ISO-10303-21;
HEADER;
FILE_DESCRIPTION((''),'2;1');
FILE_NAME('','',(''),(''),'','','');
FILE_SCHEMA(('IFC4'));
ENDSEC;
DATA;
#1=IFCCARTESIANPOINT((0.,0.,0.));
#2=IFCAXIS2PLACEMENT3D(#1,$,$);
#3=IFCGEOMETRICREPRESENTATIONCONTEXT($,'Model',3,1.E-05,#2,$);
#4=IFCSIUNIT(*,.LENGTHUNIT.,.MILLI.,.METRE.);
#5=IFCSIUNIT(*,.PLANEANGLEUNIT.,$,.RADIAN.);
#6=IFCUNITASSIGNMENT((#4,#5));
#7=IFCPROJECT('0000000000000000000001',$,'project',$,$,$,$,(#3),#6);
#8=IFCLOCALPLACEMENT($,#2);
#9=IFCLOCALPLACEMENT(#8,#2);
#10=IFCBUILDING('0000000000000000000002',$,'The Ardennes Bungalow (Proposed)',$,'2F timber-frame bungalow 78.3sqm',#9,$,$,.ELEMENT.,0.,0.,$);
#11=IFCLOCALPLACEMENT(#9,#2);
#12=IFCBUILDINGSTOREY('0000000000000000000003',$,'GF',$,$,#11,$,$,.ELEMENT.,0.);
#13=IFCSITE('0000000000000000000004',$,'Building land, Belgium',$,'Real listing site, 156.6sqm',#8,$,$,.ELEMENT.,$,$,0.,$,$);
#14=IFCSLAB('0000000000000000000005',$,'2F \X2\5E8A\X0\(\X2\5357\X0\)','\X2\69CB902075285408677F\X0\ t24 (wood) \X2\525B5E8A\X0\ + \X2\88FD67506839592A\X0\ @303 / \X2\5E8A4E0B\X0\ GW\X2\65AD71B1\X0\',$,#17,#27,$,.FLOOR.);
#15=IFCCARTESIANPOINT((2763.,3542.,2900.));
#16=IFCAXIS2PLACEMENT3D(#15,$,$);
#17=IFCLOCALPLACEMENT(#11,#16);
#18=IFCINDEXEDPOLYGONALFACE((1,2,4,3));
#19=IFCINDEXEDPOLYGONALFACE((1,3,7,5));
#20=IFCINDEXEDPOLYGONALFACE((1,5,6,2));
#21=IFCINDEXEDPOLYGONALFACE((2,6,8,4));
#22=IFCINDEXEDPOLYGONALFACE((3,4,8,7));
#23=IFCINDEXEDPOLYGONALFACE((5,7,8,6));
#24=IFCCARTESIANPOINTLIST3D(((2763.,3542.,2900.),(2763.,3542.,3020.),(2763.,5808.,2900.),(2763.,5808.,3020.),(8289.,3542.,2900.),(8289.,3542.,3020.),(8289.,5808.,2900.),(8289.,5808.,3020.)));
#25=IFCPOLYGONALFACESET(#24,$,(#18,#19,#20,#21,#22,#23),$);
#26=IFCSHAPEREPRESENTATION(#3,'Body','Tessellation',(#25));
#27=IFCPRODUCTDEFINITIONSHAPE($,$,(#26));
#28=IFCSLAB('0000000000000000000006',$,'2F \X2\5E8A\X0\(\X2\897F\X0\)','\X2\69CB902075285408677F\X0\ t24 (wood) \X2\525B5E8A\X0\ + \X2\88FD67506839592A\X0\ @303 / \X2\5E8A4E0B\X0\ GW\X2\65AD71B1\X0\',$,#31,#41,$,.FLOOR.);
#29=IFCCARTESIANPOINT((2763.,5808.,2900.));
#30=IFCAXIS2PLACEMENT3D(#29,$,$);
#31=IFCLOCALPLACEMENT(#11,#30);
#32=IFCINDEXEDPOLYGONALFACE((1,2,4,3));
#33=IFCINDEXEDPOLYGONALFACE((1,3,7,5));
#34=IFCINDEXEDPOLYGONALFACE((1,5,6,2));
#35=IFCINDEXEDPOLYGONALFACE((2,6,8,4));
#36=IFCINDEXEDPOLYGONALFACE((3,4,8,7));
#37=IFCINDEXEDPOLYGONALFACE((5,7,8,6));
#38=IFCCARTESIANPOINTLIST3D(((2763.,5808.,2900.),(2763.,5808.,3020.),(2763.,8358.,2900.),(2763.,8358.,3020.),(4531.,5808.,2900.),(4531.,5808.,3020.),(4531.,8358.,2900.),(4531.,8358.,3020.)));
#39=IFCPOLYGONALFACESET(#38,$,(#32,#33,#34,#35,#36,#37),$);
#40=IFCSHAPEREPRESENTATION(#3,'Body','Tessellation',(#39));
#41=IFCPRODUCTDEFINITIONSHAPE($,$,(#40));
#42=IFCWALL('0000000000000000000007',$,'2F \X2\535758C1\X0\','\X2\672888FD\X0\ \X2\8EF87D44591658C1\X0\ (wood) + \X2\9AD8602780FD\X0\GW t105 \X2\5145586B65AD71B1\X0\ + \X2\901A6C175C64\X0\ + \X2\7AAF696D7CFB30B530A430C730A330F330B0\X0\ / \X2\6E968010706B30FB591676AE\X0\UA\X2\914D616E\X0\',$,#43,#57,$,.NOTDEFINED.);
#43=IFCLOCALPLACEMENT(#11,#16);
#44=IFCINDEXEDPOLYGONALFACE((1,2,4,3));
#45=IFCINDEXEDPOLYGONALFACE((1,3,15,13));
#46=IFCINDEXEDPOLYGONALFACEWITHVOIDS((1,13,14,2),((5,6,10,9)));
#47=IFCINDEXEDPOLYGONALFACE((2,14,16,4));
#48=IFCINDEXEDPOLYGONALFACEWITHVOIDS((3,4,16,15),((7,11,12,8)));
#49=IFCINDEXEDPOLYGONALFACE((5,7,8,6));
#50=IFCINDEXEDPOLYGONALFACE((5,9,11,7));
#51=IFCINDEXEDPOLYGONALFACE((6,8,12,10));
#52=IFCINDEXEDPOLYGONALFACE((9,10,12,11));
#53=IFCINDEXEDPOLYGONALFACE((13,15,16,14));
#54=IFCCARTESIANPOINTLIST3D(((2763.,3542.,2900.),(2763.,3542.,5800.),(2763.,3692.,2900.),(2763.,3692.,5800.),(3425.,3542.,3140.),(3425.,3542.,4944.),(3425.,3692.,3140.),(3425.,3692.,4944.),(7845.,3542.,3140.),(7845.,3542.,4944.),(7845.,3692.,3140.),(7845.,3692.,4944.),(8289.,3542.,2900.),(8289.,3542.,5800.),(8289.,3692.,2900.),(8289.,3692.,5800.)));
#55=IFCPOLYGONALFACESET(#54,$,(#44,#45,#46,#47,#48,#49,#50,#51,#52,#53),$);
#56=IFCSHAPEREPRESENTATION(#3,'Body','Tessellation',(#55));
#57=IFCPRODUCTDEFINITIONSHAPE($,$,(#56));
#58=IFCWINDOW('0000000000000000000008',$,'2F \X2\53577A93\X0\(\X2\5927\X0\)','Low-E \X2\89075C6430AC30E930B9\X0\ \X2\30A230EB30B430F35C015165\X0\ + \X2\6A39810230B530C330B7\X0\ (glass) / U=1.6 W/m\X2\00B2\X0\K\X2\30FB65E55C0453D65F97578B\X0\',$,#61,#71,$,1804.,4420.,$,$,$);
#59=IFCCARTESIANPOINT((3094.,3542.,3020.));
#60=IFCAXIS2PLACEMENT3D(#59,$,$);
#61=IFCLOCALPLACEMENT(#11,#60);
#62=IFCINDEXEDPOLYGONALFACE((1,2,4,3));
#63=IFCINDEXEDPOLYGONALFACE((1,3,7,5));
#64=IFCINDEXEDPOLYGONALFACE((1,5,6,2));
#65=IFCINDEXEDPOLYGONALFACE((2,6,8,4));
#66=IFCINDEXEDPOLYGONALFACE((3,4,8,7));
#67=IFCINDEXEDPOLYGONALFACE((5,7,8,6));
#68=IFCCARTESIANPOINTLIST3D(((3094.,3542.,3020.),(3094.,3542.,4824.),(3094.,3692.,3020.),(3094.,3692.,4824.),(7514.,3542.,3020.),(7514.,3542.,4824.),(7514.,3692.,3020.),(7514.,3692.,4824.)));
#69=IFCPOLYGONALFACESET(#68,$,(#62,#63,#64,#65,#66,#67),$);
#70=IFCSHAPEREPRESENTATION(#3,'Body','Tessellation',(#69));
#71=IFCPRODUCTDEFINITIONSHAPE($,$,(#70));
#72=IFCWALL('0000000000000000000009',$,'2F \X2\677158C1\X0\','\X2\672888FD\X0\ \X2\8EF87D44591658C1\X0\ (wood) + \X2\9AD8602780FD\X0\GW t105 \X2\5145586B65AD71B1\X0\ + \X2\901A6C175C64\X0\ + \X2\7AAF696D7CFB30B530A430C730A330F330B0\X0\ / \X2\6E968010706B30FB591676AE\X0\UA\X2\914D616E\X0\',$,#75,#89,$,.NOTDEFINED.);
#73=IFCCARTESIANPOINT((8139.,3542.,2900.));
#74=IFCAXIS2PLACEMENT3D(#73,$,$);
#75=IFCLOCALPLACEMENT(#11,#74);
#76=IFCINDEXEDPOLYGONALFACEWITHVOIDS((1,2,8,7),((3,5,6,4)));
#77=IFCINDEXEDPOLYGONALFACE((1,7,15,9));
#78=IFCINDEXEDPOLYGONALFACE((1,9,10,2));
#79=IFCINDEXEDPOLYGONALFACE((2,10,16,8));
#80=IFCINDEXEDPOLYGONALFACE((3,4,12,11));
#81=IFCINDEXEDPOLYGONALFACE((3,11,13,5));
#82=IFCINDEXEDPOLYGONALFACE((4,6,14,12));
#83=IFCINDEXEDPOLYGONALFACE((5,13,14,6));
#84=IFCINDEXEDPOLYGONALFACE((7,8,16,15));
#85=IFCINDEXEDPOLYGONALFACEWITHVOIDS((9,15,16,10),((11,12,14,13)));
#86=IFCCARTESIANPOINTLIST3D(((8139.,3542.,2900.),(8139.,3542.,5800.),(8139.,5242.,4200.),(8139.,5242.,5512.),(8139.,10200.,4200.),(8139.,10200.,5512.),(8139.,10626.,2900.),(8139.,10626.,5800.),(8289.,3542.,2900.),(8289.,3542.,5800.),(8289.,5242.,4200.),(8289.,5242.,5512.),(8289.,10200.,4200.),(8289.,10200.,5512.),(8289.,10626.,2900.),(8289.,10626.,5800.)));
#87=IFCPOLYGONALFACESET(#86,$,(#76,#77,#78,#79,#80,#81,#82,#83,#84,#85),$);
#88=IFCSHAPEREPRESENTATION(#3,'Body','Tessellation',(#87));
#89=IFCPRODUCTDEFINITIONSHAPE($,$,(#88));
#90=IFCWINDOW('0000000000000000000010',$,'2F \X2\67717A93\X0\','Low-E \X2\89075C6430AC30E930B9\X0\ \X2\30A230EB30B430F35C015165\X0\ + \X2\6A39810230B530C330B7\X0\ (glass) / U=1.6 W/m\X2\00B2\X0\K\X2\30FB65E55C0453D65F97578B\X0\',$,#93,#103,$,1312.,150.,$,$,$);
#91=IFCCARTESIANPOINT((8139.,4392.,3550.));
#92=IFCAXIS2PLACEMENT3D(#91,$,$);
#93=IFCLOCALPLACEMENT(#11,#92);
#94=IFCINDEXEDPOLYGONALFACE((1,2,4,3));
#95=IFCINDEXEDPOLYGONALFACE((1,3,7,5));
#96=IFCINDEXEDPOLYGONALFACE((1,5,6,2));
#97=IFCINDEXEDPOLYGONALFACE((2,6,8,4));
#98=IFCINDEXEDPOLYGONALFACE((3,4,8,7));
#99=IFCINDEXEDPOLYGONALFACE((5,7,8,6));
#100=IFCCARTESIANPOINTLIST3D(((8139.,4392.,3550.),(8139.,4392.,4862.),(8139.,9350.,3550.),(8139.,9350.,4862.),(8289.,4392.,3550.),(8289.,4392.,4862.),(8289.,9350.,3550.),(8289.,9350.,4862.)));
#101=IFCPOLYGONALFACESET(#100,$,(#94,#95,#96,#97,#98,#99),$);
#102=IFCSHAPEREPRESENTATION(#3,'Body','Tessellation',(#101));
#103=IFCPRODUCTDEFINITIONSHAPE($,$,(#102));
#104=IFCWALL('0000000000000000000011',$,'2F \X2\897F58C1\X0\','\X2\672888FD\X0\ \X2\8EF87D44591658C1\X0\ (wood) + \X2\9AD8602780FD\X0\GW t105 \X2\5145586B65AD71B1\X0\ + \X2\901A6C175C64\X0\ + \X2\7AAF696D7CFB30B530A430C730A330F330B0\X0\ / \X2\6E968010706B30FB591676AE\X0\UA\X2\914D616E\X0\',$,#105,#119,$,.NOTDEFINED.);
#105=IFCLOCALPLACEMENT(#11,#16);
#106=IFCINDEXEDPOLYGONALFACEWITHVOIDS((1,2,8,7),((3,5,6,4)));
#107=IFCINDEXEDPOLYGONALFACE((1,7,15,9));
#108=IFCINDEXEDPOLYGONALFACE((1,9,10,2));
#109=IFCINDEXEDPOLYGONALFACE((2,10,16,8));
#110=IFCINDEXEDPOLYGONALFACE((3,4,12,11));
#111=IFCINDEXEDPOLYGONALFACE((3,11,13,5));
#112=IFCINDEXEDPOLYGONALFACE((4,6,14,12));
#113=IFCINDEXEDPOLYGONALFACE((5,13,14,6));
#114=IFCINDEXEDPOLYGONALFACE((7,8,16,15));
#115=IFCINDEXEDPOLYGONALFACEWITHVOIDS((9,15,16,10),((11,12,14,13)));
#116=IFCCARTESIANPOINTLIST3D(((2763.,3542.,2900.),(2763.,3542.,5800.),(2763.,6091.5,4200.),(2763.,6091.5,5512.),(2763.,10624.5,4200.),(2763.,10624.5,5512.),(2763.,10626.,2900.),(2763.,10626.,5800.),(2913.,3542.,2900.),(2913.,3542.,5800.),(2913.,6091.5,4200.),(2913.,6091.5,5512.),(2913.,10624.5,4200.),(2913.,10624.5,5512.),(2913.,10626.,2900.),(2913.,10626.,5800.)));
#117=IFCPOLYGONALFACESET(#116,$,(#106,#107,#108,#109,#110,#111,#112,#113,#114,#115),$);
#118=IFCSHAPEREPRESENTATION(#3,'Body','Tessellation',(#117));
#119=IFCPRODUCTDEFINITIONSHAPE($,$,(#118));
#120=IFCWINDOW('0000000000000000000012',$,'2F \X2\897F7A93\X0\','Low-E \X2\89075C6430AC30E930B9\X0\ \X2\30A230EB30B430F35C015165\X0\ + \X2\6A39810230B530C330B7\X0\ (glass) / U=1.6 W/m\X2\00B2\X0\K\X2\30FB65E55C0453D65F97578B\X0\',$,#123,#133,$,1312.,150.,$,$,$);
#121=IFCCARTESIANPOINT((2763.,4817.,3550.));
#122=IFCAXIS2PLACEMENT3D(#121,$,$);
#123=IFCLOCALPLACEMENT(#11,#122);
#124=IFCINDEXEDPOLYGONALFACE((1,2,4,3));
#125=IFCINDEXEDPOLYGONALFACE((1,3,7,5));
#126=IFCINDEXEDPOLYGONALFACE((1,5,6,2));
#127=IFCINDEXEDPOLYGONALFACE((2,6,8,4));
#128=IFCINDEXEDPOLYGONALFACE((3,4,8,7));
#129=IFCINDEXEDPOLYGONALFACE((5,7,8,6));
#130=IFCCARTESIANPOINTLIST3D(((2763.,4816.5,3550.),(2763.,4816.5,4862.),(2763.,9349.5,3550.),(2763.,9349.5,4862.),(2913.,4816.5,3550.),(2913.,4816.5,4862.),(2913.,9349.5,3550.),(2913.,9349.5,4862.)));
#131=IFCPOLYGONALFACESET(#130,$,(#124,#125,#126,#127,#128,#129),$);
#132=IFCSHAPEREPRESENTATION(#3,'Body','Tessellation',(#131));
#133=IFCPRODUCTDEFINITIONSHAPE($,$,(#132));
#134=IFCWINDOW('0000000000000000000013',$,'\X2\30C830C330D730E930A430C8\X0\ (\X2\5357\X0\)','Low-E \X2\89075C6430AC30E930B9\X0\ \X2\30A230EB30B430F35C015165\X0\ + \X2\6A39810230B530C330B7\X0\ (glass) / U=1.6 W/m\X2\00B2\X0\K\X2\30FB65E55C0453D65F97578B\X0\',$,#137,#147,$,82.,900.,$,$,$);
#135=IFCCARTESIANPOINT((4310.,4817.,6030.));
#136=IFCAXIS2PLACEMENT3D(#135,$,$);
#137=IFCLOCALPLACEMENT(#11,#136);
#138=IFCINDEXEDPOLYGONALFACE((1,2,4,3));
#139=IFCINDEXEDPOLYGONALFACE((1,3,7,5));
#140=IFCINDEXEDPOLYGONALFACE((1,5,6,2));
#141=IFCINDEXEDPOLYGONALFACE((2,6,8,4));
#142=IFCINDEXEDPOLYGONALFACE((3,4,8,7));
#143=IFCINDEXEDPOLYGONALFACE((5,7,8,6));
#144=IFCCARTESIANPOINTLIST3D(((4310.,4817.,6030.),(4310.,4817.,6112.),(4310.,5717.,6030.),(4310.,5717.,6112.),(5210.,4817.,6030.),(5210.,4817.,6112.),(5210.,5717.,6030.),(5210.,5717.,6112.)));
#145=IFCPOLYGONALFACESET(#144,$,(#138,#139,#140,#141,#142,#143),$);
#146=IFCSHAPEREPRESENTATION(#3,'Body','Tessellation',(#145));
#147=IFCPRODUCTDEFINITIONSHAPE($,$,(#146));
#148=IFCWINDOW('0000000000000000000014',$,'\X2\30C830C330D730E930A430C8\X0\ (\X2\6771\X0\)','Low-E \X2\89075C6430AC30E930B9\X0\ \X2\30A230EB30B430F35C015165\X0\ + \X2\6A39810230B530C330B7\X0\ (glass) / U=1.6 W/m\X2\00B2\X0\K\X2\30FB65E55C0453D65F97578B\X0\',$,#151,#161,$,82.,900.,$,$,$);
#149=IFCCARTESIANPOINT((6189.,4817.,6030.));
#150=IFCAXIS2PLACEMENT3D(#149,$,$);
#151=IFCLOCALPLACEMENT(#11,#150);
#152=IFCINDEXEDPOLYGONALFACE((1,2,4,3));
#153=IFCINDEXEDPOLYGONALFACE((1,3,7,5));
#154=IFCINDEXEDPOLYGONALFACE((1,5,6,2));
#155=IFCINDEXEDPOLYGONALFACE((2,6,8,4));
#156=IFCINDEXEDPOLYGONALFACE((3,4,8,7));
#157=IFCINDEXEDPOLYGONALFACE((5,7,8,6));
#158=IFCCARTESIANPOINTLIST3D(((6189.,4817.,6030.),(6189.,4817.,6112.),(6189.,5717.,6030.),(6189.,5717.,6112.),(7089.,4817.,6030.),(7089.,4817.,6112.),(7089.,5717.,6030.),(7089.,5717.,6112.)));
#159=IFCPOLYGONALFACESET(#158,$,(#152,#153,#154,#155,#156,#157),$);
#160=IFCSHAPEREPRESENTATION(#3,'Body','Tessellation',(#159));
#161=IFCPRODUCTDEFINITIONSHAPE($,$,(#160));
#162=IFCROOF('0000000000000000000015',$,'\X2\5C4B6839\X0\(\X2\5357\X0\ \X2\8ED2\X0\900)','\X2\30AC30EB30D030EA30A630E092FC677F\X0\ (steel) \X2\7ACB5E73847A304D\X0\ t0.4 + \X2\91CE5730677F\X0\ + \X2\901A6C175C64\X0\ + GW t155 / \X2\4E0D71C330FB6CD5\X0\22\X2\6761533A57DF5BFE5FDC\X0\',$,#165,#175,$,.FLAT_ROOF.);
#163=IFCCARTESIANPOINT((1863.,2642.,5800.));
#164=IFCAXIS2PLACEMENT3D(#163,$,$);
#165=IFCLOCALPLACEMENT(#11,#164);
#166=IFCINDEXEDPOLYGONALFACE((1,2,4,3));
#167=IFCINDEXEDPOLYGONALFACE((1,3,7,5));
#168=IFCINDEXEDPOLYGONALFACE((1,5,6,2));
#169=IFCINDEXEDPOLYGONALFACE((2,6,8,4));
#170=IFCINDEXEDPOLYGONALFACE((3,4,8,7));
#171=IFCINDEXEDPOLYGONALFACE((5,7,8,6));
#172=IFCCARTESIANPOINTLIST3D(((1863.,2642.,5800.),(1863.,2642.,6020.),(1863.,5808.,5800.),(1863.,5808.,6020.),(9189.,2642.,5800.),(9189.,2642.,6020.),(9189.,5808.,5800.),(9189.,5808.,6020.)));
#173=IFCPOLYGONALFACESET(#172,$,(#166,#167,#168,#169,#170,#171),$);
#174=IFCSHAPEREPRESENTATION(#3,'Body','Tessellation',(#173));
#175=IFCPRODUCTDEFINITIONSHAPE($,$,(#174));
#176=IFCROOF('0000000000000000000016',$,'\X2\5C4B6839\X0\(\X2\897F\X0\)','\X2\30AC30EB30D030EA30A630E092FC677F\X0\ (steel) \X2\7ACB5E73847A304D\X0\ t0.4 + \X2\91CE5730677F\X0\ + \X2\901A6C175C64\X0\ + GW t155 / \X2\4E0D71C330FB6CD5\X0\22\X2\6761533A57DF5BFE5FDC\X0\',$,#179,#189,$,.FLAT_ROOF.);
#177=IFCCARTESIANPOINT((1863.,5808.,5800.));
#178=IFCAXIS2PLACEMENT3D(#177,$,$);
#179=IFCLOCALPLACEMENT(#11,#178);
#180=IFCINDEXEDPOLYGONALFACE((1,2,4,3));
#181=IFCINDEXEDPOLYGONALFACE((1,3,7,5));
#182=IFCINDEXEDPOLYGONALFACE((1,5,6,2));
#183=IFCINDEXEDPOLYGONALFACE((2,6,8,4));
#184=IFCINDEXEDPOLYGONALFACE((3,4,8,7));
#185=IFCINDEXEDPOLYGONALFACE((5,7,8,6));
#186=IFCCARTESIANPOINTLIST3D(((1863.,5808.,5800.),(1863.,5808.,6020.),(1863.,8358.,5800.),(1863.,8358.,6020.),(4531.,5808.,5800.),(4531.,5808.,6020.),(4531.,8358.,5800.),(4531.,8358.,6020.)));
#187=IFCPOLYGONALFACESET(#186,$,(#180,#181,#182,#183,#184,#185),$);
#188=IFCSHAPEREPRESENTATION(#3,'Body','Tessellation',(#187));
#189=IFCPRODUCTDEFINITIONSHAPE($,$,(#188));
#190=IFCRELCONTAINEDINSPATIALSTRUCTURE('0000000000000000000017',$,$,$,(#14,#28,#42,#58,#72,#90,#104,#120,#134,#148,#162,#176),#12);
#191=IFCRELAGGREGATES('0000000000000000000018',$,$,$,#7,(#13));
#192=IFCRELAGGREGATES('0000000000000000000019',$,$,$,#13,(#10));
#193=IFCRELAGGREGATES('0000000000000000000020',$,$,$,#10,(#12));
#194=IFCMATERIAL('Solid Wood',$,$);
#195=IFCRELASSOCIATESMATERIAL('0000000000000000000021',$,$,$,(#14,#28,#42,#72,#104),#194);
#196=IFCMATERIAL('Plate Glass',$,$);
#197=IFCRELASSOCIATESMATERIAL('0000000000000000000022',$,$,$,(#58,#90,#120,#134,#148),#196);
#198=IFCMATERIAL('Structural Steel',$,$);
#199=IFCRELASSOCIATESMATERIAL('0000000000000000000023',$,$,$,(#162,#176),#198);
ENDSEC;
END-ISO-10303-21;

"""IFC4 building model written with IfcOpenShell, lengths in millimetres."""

from ifc_helpers import new_model, si_unit, frame, frame_2d, origin, place, context, project, spatial, rectangle, extrude, material, element, fill, save


model = new_model("IFC4")

# Units and contexts
model_context = context("Model", 3, precision=1e-05, world=origin())
ifc_project = project(units=[si_unit("LENGTHUNIT", "METRE", prefix="MILLI"), si_unit("PLANEANGLEUNIT", "RADIAN")], contexts=[model_context])

# Site, building, storey
site_placement = place(None, origin())
site = spatial("IfcSite", under=ifc_project, at=site_placement, Name="Building land, Belgium", ObjectType="Real listing site, 156.6sqm", CompositionType="ELEMENT", RefElevation=0.0)
building_placement = place(site_placement, origin())
building = spatial("IfcBuilding", under=site, at=building_placement, Name="The Ardennes Bungalow (Proposed)", ObjectType="2F timber-frame bungalow 78.3sqm", CompositionType="ELEMENT", ElevationOfRefHeight=0.0, ElevationOfTerrain=0.0)
storey_placement = place(building_placement, origin())
storey = spatial("IfcBuildingStorey", under=building, at=storey_placement, Name="GF", CompositionType="ELEMENT", Elevation=0.0)

# Slabs
ifc_material_1 = material(Name="Solid Wood")
slab_1_placement = place(storey_placement, frame((2763.0, 3542.0, 2900.0)))
element("IfcSlab", 1, at=slab_1_placement, inside=storey, material=ifc_material_1, Name="2F 床(南)", Description="構造用合板 t24 (wood) 剛床 + 製材根太 @303 / 床下 GW断熱", PredefinedType="FLOOR", context=model_context, shape_type="SweptSolid", body=[
    extrude(rectangle(XDim=5526.0, YDim=2266.0, at=frame_2d((2763.0, 1133.0))), frame((2763.0, 3542.0, 2900.0)), (0.0, 0.0, 1.0), 120.0),
])
slab_2_placement = place(storey_placement, frame((2763.0, 5808.0, 2900.0)))
element("IfcSlab", 2, at=slab_2_placement, inside=storey, material=ifc_material_1, Name="2F 床(西)", Description="構造用合板 t24 (wood) 剛床 + 製材根太 @303 / 床下 GW断熱", PredefinedType="FLOOR", context=model_context, shape_type="SweptSolid", body=[
    extrude(rectangle(XDim=1768.0, YDim=2550.0, at=frame_2d((884.0, 1275.0))), frame((2763.0, 5808.0, 2900.0)), (0.0, 0.0, 1.0), 120.0),
])

# Walls, openings, windows
wall_1_placement = place(storey_placement, frame((2763.0, 3542.0, 2900.0)))
wall_1 = element("IfcWall", 3, at=wall_1_placement, inside=storey, material=ifc_material_1, Name="2F 南壁", Description="木製 軸組外壁 (wood) + 高性能GW t105 充填断熱 + 通気層 + 窯業系サイディング / 準耐火・外皮UA配慮", PredefinedType="NOTDEFINED", context=model_context, shape_type="SweptSolid", body=[
    extrude(rectangle(XDim=5526.0, YDim=150.0, at=frame_2d((2763.0, 75.0))), frame((2763.0, 3542.0, 2900.0)), (0.0, 0.0, 1.0), 2900.0),
])
opening_1_placement = place(storey_placement, frame((3094.0, 3542.0, 3020.0)))
opening_1 = element("IfcOpeningElement", 4, at=opening_1_placement, cuts=wall_1, PredefinedType="NOTDEFINED", context=model_context, shape_type="SweptSolid", body=[
    extrude(rectangle(XDim=4420.0, YDim=150.0, at=frame_2d((2210.0, 75.0))), frame((3094.0, 3542.0, 3020.0)), (0.0, 0.0, 1.0), 1804.0),
])
ifc_material_2 = material(Name="Plate Glass")
window_1_placement = place(storey_placement, frame((3094.0, 3542.0, 3020.0)))
window_1 = element("IfcWindow", 5, at=window_1_placement, inside=storey, material=ifc_material_2, Name="2F 南窓(大)", Description="Low-E 複層ガラス アルゴン封入 + 樹脂サッシ (glass) / U=1.6 W/m²K・日射取得型", OverallHeight=1804.0, OverallWidth=4420.0, context=model_context, shape_type="SweptSolid", body=[
    extrude(rectangle(XDim=4420.0, YDim=150.0, at=frame_2d((2210.0, 75.0))), frame((3094.0, 3542.0, 3020.0)), (0.0, 0.0, 1.0), 1804.0),
])
fill(opening_1, window_1)
wall_2_placement = place(storey_placement, frame((8139.0, 3542.0, 2900.0)))
wall_2 = element("IfcWall", 6, at=wall_2_placement, inside=storey, material=ifc_material_1, Name="2F 東壁", Description="木製 軸組外壁 (wood) + 高性能GW t105 充填断熱 + 通気層 + 窯業系サイディング / 準耐火・外皮UA配慮", PredefinedType="NOTDEFINED", context=model_context, shape_type="SweptSolid", body=[
    extrude(rectangle(XDim=150.0, YDim=7084.0, at=frame_2d((75.0, 3542.0))), frame((8139.0, 3542.0, 2900.0)), (0.0, 0.0, 1.0), 2900.0),
])
opening_2_placement = place(storey_placement, frame((8139.0, 4392.0, 3550.0)))
opening_2 = element("IfcOpeningElement", 7, at=opening_2_placement, cuts=wall_2, PredefinedType="NOTDEFINED", context=model_context, shape_type="SweptSolid", body=[
    extrude(rectangle(XDim=150.0, YDim=4958.0, at=frame_2d((75.0, 2479.0))), frame((8139.0, 4392.0, 3550.0)), (0.0, 0.0, 1.0), 1312.0),
])
window_2_placement = place(storey_placement, frame((8139.0, 4392.0, 3550.0)))
window_2 = element("IfcWindow", 8, at=window_2_placement, inside=storey, material=ifc_material_2, Name="2F 東窓", Description="Low-E 複層ガラス アルゴン封入 + 樹脂サッシ (glass) / U=1.6 W/m²K・日射取得型", OverallHeight=1312.0, OverallWidth=150.0, context=model_context, shape_type="SweptSolid", body=[
    extrude(rectangle(XDim=150.0, YDim=4958.0, at=frame_2d((75.0, 2479.0))), frame((8139.0, 4392.0, 3550.0)), (0.0, 0.0, 1.0), 1312.0),
])
fill(opening_2, window_2)
wall_3_placement = place(storey_placement, frame((2763.0, 3542.0, 2900.0)))
wall_3 = element("IfcWall", 9, at=wall_3_placement, inside=storey, material=ifc_material_1, Name="2F 西壁", Description="木製 軸組外壁 (wood) + 高性能GW t105 充填断熱 + 通気層 + 窯業系サイディング / 準耐火・外皮UA配慮", PredefinedType="NOTDEFINED", context=model_context, shape_type="SweptSolid", body=[
    extrude(rectangle(XDim=150.0, YDim=7084.0, at=frame_2d((75.0, 3542.0))), frame((2763.0, 3542.0, 2900.0)), (0.0, 0.0, 1.0), 2900.0),
])
opening_3_placement = place(storey_placement, frame((2763.0, 4817.0, 3550.0)))
opening_3 = element("IfcOpeningElement", 10, at=opening_3_placement, cuts=wall_3, PredefinedType="NOTDEFINED", context=model_context, shape_type="SweptSolid", body=[
    extrude(rectangle(XDim=150.0, YDim=4533.0, at=frame_2d((75.0, 2266.0))), frame((2763.0, 4817.0, 3550.0)), (0.0, 0.0, 1.0), 1312.0),
])
window_3_placement = place(storey_placement, frame((2763.0, 4817.0, 3550.0)))
window_3 = element("IfcWindow", 11, at=window_3_placement, inside=storey, material=ifc_material_2, Name="2F 西窓", Description="Low-E 複層ガラス アルゴン封入 + 樹脂サッシ (glass) / U=1.6 W/m²K・日射取得型", OverallHeight=1312.0, OverallWidth=150.0, context=model_context, shape_type="SweptSolid", body=[
    extrude(rectangle(XDim=150.0, YDim=4533.0, at=frame_2d((75.0, 2266.0))), frame((2763.0, 4817.0, 3550.0)), (0.0, 0.0, 1.0), 1312.0),
])
fill(opening_3, window_3)

# Windows
window_4_placement = place(storey_placement, frame((4310.0, 4817.0, 6030.0)))
element("IfcWindow", 12, at=window_4_placement, inside=storey, material=ifc_material_2, Name="トップライト (南)", Description="Low-E 複層ガラス アルゴン封入 + 樹脂サッシ (glass) / U=1.6 W/m²K・日射取得型", OverallHeight=82.0, OverallWidth=900.0, context=model_context, shape_type="SweptSolid", body=[
    extrude(rectangle(XDim=900.0, YDim=900.0, at=frame_2d((450.0, 450.0))), frame((4310.0, 4817.0, 6030.0)), (0.0, 0.0, 1.0), 82.0),
])
window_5_placement = place(storey_placement, frame((6189.0, 4817.0, 6030.0)))
element("IfcWindow", 13, at=window_5_placement, inside=storey, material=ifc_material_2, Name="トップライト (東)", Description="Low-E 複層ガラス アルゴン封入 + 樹脂サッシ (glass) / U=1.6 W/m²K・日射取得型", OverallHeight=82.0, OverallWidth=900.0, context=model_context, shape_type="SweptSolid", body=[
    extrude(rectangle(XDim=900.0, YDim=900.0, at=frame_2d((450.0, 450.0))), frame((6189.0, 4817.0, 6030.0)), (0.0, 0.0, 1.0), 82.0),
])

# Roofs
ifc_material_3 = material(Name="Structural Steel")
roof_1_placement = place(storey_placement, frame((1863.0, 2642.0, 5800.0)))
element("IfcRoof", 14, at=roof_1_placement, inside=storey, material=ifc_material_3, Name="屋根(南 軒900)", Description="ガルバリウム鋼板 (steel) 立平葺き t0.4 + 野地板 + 通気層 + GW t155 / 不燃・法22条区域対応", PredefinedType="FLAT_ROOF", context=model_context, shape_type="SweptSolid", body=[
    extrude(rectangle(XDim=7326.0, YDim=3166.0, at=frame_2d((3663.0, 1583.0))), frame((1863.0, 2642.0, 5800.0)), (0.0, 0.0, 1.0), 220.0),
])
roof_2_placement = place(storey_placement, frame((1863.0, 5808.0, 5800.0)))
element("IfcRoof", 15, at=roof_2_placement, inside=storey, material=ifc_material_3, Name="屋根(西)", Description="ガルバリウム鋼板 (steel) 立平葺き t0.4 + 野地板 + 通気層 + GW t155 / 不燃・法22条区域対応", PredefinedType="FLAT_ROOF", context=model_context, shape_type="SweptSolid", body=[
    extrude(rectangle(XDim=2668.0, YDim=2550.0, at=frame_2d((1334.0, 1275.0))), frame((1863.0, 5808.0, 5800.0)), (0.0, 0.0, 1.0), 220.0),
])

save(model, "model.ifc")
